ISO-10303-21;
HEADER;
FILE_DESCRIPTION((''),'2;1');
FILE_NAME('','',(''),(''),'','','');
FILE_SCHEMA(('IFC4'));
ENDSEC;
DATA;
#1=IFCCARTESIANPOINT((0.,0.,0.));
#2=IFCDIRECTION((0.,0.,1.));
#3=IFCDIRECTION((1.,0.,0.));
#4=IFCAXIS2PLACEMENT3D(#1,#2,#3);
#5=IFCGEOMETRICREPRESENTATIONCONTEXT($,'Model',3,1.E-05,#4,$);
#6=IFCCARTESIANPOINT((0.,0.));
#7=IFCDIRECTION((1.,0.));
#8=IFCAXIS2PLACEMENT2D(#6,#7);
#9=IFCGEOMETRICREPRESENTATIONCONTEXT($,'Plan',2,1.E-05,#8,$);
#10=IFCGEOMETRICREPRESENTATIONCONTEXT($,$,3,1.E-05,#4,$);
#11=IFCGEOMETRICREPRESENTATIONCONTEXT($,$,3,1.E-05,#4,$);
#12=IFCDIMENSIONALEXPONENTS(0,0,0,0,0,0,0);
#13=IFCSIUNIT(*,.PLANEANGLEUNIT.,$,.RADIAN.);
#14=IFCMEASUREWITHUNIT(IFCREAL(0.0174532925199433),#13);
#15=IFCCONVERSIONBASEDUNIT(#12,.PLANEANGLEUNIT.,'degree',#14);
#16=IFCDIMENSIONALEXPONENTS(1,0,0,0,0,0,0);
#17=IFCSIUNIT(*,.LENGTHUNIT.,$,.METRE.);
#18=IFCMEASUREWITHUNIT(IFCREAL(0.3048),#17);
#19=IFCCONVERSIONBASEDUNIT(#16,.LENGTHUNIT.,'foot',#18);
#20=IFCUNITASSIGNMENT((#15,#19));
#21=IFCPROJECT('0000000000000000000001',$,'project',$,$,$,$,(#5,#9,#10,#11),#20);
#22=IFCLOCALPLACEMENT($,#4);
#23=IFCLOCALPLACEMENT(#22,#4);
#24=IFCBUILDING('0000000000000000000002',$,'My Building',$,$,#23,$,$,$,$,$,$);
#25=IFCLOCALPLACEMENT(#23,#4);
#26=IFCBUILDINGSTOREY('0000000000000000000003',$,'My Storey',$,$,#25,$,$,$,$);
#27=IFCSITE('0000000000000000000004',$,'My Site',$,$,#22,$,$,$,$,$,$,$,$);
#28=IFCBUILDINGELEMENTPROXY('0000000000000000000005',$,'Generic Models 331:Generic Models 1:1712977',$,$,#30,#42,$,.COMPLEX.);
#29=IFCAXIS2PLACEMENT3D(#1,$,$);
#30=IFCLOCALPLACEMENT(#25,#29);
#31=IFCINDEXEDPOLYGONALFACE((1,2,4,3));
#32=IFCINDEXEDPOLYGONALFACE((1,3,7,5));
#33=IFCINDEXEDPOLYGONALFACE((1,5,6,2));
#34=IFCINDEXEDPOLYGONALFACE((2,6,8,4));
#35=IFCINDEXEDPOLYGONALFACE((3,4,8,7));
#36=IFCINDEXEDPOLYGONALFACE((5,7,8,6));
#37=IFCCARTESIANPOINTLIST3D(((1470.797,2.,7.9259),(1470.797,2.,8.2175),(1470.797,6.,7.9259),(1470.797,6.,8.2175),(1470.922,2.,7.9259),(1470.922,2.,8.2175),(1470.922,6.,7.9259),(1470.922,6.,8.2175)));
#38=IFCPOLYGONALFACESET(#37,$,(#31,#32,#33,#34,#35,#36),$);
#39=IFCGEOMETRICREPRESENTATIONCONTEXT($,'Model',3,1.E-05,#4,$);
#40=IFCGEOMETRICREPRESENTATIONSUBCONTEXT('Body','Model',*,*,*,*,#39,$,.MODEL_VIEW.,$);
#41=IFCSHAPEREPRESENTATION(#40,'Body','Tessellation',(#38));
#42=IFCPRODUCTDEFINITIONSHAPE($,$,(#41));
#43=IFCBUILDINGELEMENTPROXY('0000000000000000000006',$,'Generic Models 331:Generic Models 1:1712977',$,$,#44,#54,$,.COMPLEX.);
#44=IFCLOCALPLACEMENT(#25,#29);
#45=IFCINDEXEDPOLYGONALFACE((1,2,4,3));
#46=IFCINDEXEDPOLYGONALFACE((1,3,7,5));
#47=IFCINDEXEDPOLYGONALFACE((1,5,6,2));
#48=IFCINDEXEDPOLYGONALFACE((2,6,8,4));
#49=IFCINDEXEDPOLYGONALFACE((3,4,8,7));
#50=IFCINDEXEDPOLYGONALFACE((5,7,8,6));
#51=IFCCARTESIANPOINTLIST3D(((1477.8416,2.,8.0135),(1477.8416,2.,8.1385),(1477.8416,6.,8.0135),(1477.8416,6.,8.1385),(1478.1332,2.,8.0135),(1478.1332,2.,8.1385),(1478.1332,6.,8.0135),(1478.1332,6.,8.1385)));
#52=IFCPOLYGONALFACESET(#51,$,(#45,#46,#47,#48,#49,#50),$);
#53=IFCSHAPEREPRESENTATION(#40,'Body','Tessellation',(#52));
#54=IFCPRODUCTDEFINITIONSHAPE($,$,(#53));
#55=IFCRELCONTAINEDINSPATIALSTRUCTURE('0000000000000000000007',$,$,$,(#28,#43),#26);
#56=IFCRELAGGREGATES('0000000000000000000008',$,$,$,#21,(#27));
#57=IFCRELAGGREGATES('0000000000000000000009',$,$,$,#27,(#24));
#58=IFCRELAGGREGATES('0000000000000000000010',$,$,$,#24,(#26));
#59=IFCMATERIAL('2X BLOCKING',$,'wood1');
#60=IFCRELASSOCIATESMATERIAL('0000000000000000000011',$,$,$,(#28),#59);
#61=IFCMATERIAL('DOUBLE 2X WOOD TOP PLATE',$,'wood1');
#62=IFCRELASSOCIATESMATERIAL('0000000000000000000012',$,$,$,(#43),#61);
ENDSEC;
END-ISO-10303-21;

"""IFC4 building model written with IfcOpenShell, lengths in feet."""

from ifc_helpers import new_model, entity, si_unit, converted_unit, frame, origin_with_axes, origin_2d_with_axis, place, context, subcontext, project, spatial, polyline, outline, extrude, material, element, save


model = new_model("IFC4")

# Units and contexts
model_context_1 = context("Model", 3, precision=1e-05, world=origin_with_axes())
plan_context = context("Plan", 2, precision=1e-05, world=origin_2d_with_axis())
model_context_2 = context("Model", 3, precision=1e-05, world=origin_with_axes())
context_of_model_1 = context(None, 3, precision=1e-05, world=origin_with_axes())
context_of_model_2 = context(None, 3, precision=1e-05, world=origin_with_axes())
body_context = subcontext(model_context_2, "Body", "Model", "MODEL_VIEW")
ifc_project = project(units=[converted_unit("PLANEANGLEUNIT", "degree", entity("IfcReal", 0.0174532925199433), si_unit("PLANEANGLEUNIT", "RADIAN"), dimensions=[0, 0, 0, 0, 0, 0, 0]), converted_unit("LENGTHUNIT", "foot", entity("IfcReal", 0.3048), si_unit("LENGTHUNIT", "METRE"), dimensions=[1, 0, 0, 0, 0, 0, 0])], contexts=[model_context_1, plan_context, context_of_model_1, context_of_model_2])

# Site, building, storey
site_placement = place(None, origin_with_axes())
site = spatial("IfcSite", under=ifc_project, at=site_placement, Name="My Site")
building_placement = place(site_placement, origin_with_axes())
building = spatial("IfcBuilding", under=site, at=building_placement, Name="My Building")
storey_placement = place(building_placement, origin_with_axes())
storey = spatial("IfcBuildingStorey", under=building, at=storey_placement, Name="My Storey")

# Building element proxies
ifc_material_1 = material(Name="DOUBLE 2X WOOD TOP PLATE", Category="wood1")
ifc_material_2 = material(Name="2X BLOCKING", Category="wood1")
proxy_1_placement = place(storey_placement, frame((1470.922, 6.0, 7.9259), z_axis=(0.0, -1.0, 0.0), x_axis=(-1.0, 0.0, 0.0)))
element("IfcBuildingElementProxy", 1, at=proxy_1_placement, inside=storey, material=ifc_material_2, Name="Generic Models 331:Generic Models 1:1712977", PredefinedType="COMPLEX", context=body_context, shape_type="SweptSolid", body=[
    extrude(outline(polyline([(-0.1458, -0.0625), (0.1458, -0.0625), (0.1458, 0.0625), (-0.1458, 0.0625), (-0.1458, -0.0625)])), frame((0.0625, -0.1458, 0.0), z_axis=(0.0, 0.0, -1.0), x_axis=(0.0, -1.0, 0.0)), (0.0, 0.0, -1.0), 4.0),
])
proxy_2_placement = place(storey_placement, frame((1477.8416, 6.0, 8.0135), z_axis=(0.0, -1.0, 0.0), x_axis=(0.0, 0.0, 1.0)))
element("IfcBuildingElementProxy", 2, at=proxy_2_placement, inside=storey, material=ifc_material_1, Name="Generic Models 331:Generic Models 1:1712977", PredefinedType="COMPLEX", context=body_context, shape_type="SweptSolid", body=[
    extrude(outline(polyline([(-0.1458, -0.0625), (0.1458, -0.0625), (0.1458, 0.0625), (-0.1458, 0.0625), (-0.1458, -0.0625)])), frame((0.0625, -0.1458, 0.0), z_axis=(0.0, 0.0, -1.0), x_axis=(0.0, -1.0, 0.0)), (0.0, 0.0, -1.0), 4.0),
])

save(model, "model.ifc")
